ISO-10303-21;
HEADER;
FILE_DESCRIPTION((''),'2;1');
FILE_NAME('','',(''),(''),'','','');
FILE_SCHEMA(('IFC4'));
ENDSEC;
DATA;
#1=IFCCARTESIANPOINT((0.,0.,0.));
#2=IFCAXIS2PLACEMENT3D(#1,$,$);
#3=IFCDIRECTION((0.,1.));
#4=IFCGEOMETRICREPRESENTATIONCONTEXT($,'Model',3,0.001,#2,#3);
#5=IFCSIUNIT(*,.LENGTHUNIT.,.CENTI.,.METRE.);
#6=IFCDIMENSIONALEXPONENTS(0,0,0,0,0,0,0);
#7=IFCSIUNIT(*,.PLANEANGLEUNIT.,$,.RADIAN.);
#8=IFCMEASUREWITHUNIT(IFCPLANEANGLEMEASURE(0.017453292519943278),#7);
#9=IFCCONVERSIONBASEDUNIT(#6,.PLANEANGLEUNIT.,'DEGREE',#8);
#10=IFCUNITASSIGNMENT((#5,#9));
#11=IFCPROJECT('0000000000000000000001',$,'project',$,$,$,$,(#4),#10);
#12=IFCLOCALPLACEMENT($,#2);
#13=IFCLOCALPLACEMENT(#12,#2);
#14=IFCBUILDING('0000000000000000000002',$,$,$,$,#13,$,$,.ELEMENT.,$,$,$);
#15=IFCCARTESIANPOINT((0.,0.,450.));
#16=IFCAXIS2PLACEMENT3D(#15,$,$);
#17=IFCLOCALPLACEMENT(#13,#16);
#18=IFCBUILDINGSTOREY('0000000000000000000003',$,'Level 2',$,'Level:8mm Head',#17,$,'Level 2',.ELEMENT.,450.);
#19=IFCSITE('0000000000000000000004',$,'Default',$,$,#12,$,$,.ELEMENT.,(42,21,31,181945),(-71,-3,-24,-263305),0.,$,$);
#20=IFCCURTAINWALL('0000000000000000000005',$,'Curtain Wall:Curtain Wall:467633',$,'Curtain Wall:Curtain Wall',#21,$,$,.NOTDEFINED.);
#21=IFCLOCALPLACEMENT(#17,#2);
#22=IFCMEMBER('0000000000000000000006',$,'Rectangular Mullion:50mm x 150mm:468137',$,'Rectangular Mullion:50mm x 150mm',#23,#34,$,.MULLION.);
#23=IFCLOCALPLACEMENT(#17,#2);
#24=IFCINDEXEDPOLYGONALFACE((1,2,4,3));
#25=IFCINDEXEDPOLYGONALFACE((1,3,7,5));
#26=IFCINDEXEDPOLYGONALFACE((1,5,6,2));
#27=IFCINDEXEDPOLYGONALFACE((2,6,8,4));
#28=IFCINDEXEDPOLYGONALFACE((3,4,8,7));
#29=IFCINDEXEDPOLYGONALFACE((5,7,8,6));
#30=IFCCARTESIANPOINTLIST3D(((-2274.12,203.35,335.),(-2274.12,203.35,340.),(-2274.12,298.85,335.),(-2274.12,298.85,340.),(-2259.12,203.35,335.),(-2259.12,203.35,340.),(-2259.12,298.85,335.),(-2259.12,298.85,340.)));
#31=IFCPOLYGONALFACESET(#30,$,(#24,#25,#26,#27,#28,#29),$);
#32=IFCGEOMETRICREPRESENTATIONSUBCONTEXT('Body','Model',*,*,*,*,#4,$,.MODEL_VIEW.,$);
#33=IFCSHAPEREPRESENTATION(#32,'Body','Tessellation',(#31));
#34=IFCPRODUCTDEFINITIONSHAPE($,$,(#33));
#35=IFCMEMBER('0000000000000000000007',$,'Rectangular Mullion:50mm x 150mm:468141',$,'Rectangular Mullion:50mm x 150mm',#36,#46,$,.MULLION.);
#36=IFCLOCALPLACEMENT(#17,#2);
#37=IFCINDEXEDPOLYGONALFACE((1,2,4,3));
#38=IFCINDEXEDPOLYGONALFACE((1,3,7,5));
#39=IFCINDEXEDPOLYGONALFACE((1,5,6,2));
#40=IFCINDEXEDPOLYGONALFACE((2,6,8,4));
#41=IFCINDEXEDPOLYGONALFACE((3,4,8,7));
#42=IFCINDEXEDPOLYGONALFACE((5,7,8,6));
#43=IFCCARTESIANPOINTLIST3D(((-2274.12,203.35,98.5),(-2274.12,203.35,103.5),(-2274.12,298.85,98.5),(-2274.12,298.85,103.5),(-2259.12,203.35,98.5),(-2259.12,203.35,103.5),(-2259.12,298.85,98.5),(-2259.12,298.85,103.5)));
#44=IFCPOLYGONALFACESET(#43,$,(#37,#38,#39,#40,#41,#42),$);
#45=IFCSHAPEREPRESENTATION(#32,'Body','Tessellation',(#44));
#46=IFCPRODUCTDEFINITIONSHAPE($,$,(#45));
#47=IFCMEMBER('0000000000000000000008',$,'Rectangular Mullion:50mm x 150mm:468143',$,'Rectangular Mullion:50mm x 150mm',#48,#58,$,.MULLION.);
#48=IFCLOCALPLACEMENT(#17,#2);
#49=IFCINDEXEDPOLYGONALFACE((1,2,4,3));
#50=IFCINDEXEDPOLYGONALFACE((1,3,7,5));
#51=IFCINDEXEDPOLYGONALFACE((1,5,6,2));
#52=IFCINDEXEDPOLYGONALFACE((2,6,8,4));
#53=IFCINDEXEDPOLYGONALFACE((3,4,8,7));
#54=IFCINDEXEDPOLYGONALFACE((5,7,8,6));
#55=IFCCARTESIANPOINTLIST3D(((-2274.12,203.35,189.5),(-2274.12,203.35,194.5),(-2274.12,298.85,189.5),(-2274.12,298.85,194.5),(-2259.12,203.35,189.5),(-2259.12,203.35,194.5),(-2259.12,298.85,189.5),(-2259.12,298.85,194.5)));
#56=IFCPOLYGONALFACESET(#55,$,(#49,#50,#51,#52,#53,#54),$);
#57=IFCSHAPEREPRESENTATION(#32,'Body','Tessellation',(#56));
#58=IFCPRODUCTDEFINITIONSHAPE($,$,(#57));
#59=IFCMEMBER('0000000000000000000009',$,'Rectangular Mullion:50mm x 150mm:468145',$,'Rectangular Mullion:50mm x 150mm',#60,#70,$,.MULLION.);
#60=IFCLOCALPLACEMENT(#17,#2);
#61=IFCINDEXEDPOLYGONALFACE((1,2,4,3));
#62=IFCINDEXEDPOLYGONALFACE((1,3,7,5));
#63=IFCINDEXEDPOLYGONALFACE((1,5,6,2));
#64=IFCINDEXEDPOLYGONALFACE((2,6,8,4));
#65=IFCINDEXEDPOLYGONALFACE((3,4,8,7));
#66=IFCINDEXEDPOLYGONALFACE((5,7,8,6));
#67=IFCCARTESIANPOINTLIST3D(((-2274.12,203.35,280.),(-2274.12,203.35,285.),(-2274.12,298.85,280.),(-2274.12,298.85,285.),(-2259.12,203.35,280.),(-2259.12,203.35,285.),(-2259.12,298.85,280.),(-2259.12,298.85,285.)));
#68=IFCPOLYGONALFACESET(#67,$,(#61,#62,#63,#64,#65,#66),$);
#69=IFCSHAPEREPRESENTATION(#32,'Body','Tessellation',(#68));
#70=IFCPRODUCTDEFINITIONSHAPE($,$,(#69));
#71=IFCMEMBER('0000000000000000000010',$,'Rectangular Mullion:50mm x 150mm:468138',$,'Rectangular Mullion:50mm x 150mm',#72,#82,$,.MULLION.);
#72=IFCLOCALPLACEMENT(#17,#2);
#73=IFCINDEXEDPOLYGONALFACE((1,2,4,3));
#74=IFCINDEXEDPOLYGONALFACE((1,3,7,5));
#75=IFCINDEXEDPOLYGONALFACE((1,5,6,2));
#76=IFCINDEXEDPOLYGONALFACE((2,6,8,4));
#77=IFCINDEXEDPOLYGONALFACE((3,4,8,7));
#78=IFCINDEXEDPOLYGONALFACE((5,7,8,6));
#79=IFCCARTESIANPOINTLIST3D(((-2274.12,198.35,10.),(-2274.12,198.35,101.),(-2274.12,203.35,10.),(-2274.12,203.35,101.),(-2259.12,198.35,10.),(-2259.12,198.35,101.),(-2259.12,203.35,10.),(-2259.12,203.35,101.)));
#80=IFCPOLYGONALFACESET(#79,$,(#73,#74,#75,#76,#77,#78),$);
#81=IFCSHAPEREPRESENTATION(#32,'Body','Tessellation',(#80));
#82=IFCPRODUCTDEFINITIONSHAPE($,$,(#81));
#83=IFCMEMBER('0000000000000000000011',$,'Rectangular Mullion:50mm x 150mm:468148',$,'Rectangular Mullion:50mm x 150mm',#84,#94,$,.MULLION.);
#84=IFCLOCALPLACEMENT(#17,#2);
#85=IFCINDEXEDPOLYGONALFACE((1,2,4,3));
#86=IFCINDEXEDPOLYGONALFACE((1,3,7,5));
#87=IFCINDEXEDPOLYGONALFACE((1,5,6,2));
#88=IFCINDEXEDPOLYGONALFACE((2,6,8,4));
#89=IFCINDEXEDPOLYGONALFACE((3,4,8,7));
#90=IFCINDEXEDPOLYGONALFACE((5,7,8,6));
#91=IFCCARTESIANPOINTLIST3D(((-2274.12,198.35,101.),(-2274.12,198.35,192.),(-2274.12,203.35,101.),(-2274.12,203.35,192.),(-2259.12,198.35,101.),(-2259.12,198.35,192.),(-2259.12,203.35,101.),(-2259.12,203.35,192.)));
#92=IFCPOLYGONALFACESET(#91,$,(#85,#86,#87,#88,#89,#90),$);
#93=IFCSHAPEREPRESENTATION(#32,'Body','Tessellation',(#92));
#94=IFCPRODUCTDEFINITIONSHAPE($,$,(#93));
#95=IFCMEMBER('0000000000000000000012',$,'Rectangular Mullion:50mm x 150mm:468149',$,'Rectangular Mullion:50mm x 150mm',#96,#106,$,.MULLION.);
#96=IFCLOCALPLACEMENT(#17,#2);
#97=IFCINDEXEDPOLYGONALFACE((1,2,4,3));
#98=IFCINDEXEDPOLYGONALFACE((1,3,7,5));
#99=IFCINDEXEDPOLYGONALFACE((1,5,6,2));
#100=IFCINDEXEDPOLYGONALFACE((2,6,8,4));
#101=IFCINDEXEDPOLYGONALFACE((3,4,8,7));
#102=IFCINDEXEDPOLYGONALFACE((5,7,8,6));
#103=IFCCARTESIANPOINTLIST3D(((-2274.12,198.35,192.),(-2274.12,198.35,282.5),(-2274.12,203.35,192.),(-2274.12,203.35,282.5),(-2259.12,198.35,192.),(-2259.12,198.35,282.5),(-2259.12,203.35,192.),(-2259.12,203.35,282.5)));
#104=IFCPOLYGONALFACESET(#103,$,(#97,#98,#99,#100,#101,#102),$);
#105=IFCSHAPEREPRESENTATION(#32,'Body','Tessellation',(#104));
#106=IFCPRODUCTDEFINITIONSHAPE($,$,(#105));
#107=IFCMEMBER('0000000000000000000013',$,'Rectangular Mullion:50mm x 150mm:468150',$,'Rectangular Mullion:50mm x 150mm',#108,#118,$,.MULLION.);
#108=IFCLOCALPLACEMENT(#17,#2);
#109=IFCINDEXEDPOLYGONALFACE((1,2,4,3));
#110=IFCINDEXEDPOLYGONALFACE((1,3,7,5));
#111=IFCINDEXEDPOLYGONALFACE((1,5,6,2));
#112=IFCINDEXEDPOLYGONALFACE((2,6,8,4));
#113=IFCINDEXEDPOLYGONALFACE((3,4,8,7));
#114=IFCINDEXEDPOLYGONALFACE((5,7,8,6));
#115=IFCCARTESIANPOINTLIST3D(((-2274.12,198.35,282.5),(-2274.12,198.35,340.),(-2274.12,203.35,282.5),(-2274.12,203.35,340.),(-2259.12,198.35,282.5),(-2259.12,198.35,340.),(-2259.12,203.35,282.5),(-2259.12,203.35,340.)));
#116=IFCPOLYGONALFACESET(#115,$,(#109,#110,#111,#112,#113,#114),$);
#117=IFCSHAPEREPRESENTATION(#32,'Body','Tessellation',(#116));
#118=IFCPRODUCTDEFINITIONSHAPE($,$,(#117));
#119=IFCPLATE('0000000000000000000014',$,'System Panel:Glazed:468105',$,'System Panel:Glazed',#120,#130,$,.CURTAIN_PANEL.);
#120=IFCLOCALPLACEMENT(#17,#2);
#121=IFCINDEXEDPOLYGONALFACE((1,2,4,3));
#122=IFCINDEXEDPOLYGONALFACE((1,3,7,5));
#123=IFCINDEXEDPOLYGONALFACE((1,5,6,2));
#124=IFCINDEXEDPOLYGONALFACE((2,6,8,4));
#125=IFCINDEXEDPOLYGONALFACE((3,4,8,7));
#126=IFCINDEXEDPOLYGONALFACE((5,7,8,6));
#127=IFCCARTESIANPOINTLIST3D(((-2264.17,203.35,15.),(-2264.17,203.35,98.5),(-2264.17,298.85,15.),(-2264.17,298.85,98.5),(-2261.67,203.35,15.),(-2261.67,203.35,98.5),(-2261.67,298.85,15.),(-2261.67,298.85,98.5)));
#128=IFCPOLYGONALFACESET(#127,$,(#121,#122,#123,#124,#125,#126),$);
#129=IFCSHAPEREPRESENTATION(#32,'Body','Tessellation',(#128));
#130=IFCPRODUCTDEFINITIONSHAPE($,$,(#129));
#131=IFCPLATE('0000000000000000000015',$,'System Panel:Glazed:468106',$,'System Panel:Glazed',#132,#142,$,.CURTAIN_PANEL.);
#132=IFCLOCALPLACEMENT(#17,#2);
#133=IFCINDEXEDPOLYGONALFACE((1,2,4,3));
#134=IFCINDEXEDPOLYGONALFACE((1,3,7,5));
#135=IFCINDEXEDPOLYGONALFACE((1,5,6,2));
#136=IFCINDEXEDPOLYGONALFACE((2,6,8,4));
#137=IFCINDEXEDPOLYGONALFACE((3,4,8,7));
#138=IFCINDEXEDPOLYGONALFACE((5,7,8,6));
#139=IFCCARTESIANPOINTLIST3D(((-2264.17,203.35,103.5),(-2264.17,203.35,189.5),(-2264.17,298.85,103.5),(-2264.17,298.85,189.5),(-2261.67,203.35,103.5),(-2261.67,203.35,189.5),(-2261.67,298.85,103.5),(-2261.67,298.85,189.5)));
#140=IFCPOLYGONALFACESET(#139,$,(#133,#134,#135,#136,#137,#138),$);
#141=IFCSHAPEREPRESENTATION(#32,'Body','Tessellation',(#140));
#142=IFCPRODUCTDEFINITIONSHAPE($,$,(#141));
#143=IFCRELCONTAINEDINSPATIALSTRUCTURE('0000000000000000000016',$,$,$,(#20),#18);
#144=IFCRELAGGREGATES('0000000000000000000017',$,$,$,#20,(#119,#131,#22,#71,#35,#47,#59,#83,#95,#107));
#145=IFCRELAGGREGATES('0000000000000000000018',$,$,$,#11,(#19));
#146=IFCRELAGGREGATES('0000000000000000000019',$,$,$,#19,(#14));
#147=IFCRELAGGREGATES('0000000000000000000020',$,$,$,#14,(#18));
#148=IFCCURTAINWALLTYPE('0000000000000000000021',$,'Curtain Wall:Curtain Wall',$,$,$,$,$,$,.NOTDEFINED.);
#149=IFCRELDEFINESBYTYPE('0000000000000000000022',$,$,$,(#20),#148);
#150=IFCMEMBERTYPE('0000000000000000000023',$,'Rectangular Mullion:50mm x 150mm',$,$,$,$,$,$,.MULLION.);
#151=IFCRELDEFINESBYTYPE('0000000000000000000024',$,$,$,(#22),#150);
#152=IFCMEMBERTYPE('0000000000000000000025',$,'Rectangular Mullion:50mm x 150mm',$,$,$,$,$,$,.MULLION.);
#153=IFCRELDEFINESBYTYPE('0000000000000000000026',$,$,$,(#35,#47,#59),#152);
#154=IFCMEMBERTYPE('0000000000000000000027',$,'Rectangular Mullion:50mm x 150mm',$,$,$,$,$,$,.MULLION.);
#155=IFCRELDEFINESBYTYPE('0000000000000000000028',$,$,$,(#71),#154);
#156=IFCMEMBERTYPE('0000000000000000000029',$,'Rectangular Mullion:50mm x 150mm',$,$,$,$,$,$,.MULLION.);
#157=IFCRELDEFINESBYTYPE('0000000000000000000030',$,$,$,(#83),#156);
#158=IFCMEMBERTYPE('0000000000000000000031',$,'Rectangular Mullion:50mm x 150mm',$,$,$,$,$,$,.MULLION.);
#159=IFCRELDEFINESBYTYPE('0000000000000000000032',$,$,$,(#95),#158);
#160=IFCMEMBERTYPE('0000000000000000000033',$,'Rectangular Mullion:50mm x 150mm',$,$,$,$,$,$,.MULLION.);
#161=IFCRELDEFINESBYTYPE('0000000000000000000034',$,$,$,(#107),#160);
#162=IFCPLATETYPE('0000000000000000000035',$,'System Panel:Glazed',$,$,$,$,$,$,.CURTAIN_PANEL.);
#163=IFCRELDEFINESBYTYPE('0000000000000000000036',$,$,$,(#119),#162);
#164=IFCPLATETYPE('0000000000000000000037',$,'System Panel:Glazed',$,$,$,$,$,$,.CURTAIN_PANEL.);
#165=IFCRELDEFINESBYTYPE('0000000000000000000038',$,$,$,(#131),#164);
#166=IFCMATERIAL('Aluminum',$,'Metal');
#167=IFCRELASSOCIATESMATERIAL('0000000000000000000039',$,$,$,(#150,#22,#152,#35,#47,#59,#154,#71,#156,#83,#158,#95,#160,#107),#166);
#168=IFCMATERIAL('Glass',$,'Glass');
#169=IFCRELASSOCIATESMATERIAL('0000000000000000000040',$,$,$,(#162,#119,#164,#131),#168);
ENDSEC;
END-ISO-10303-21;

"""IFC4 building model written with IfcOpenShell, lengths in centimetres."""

from ifc_helpers import new_model, entity, si_unit, converted_unit, direction, frame, origin, place, context, subcontext, project, spatial, indexed_curve, outline, extrude, source, transform, mapped, material, type_object, type_shapes, element, aggregate, save


model = new_model("IFC4")

# Units and contexts
model_context = context("Model", 3, precision=0.001, world=origin(), true_north=direction((0.0, 1.0)))
body_context = subcontext(model_context, "Body", "Model", "MODEL_VIEW")
ifc_project = project(units=[si_unit("LENGTHUNIT", "METRE", prefix="CENTI"), converted_unit("PLANEANGLEUNIT", "DEGREE", entity("IfcPlaneAngleMeasure", 0.017453292519943278), si_unit("PLANEANGLEUNIT", "RADIAN"), dimensions=[0, 0, 0, 0, 0, 0, 0])], contexts=[model_context])

# Site, building, storey
site_placement = place(None, origin())
site = spatial("IfcSite", under=ifc_project, at=site_placement, Name="Default", CompositionType="ELEMENT", RefLatitude=(42, 21, 31, 181945), RefLongitude=(-71, -3, -24, -263305), RefElevation=0.0)
building_placement = place(site_placement, origin())
building = spatial("IfcBuilding", under=site, at=building_placement, CompositionType="ELEMENT")
storey_placement = place(building_placement, frame((0.0, 0.0, 450.0)))
storey = spatial("IfcBuildingStorey", under=building, at=storey_placement, Name="Level 2", ObjectType="Level:8mm Head", LongName="Level 2", CompositionType="ELEMENT", Elevation=450.0)

# Curtain wall, members, plates
curtain_wall_type = type_object("IfcCurtainWallType", Name="Curtain Wall:Curtain Wall", PredefinedType="NOTDEFINED")
curtain_wall_placement = place(storey_placement, frame((0.0, 0.0, -450.0)))
curtain_wall = element("IfcCurtainWall", 1, at=curtain_wall_placement, inside=storey, type_object=curtain_wall_type, Name="Curtain Wall:Curtain Wall:467633", ObjectType="Curtain Wall:Curtain Wall", PredefinedType="NOTDEFINED")
ifc_material_1 = material(Name="Aluminum", Category="Metal")
member_type_1 = type_object("IfcMemberType", Name="Rectangular Mullion:50mm x 150mm", PredefinedType="MULLION", material=ifc_material_1)
shared_shape_1 = source(origin(), body_context, "Body", "SweptSolid", [
    extrude(outline(indexed_curve([(-2.5, -7.5), (2.5, -7.5), (2.5, 7.5), (-2.5, 7.5), (-2.5, -7.5)], self_intersect=False)), frame((-2.5, 0.0, -95.5), z_axis=(0.0, 0.0, 1.0), x_axis=(-1.0, 0.0, 0.0)), (0.0, 0.0, 1.0), 95.5),
])
type_shapes(member_type_1, [shared_shape_1])
member_1_placement = place(curtain_wall_placement, frame((-2266.62, 203.35, 790.0), z_axis=(0.0, -1.0, 0.0), x_axis=(0.0, 0.0, 1.0)))
member_1 = element("IfcMember", 2, at=member_1_placement, type_object=member_type_1, material=ifc_material_1, Name="Rectangular Mullion:50mm x 150mm:468137", ObjectType="Rectangular Mullion:50mm x 150mm", PredefinedType="MULLION", context=body_context, shape_type="MappedRepresentation", body=[
    mapped(shared_shape_1, transform((0.0, 0.0, 0.0), scale=1.0)),
])
member_type_2 = type_object("IfcMemberType", Name="Rectangular Mullion:50mm x 150mm", PredefinedType="MULLION", material=ifc_material_1)
shared_shape_2 = source(origin(), body_context, "Body", "SweptSolid", [
    extrude(outline(indexed_curve([(-2.5, -7.5), (2.5, -7.5), (2.5, 7.5), (-2.5, 7.5), (-2.5, -7.5)], self_intersect=False)), frame((0.0, 0.0, -95.5), z_axis=(0.0, 0.0, 1.0), x_axis=(-1.0, 0.0, 0.0)), (0.0, 0.0, 1.0), 95.5),
])
type_shapes(member_type_2, [shared_shape_2])
member_2_placement = place(curtain_wall_placement, frame((-2266.62, 203.35, 551.0), z_axis=(0.0, -1.0, 0.0), x_axis=(0.0, 0.0, 1.0)))
member_2 = element("IfcMember", 3, at=member_2_placement, type_object=member_type_2, material=ifc_material_1, Name="Rectangular Mullion:50mm x 150mm:468141", ObjectType="Rectangular Mullion:50mm x 150mm", PredefinedType="MULLION", context=body_context, shape_type="MappedRepresentation", body=[
    mapped(shared_shape_2, transform((0.0, 0.0, 0.0), scale=1.0)),
])
member_3_placement = place(curtain_wall_placement, frame((-2266.62, 203.35, 642.0), z_axis=(0.0, -1.0, 0.0), x_axis=(0.0, 0.0, 1.0)))
member_3 = element("IfcMember", 4, at=member_3_placement, type_object=member_type_2, material=ifc_material_1, Name="Rectangular Mullion:50mm x 150mm:468143", ObjectType="Rectangular Mullion:50mm x 150mm", PredefinedType="MULLION", context=body_context, shape_type="MappedRepresentation", body=[
    mapped(shared_shape_2, transform((0.0, 0.0, 0.0), scale=1.0)),
])
member_4_placement = place(curtain_wall_placement, frame((-2266.62, 203.35, 732.5), z_axis=(0.0, -1.0, 0.0), x_axis=(0.0, 0.0, 1.0)))
member_4 = element("IfcMember", 5, at=member_4_placement, type_object=member_type_2, material=ifc_material_1, Name="Rectangular Mullion:50mm x 150mm:468145", ObjectType="Rectangular Mullion:50mm x 150mm", PredefinedType="MULLION", context=body_context, shape_type="MappedRepresentation", body=[
    mapped(shared_shape_2, transform((0.0, 0.0, 0.0), scale=1.0)),
])
member_type_3 = type_object("IfcMemberType", Name="Rectangular Mullion:50mm x 150mm", PredefinedType="MULLION", material=ifc_material_1)
shared_shape_3 = source(origin(), body_context, "Body", "SweptSolid", [
    extrude(outline(indexed_curve([(-2.5, -7.5), (2.5, -7.5), (2.5, 7.5), (-2.5, 7.5), (-2.5, -7.5)], self_intersect=False)), frame((-2.5, 0.0, -91.0), z_axis=(0.0, 0.0, 1.0), x_axis=(-1.0, 0.0, 0.0)), (0.0, 0.0, 1.0), 91.0),
])
type_shapes(member_type_3, [shared_shape_3])
member_5_placement = place(curtain_wall_placement, frame((-2266.62, 198.35, 460.0), z_axis=(0.0, 0.0, -1.0), x_axis=(0.0, -1.0, 0.0)))
member_5 = element("IfcMember", 6, at=member_5_placement, type_object=member_type_3, material=ifc_material_1, Name="Rectangular Mullion:50mm x 150mm:468138", ObjectType="Rectangular Mullion:50mm x 150mm", PredefinedType="MULLION", context=body_context, shape_type="MappedRepresentation", body=[
    mapped(shared_shape_3, transform((0.0, 0.0, 0.0), scale=1.0)),
])
member_type_4 = type_object("IfcMemberType", Name="Rectangular Mullion:50mm x 150mm", PredefinedType="MULLION", material=ifc_material_1)
shared_shape_4 = source(origin(), body_context, "Body", "SweptSolid", [
    extrude(outline(indexed_curve([(-2.5, -7.5), (2.5, -7.5), (2.5, 7.5), (-2.5, 7.5), (-2.5, -7.5)], self_intersect=False)), frame((-2.5, 0.0, -91.0), z_axis=(0.0, 0.0, 1.0), x_axis=(-1.0, 0.0, 0.0)), (0.0, 0.0, 1.0), 91.0),
])
type_shapes(member_type_4, [shared_shape_4])
member_6_placement = place(curtain_wall_placement, frame((-2266.62, 198.35, 551.0), z_axis=(0.0, 0.0, -1.0), x_axis=(0.0, -1.0, 0.0)))
member_6 = element("IfcMember", 7, at=member_6_placement, type_object=member_type_4, material=ifc_material_1, Name="Rectangular Mullion:50mm x 150mm:468148", ObjectType="Rectangular Mullion:50mm x 150mm", PredefinedType="MULLION", context=body_context, shape_type="MappedRepresentation", body=[
    mapped(shared_shape_4, transform((0.0, 0.0, 0.0), scale=1.0)),
])
member_type_5 = type_object("IfcMemberType", Name="Rectangular Mullion:50mm x 150mm", PredefinedType="MULLION", material=ifc_material_1)
shared_shape_5 = source(origin(), body_context, "Body", "SweptSolid", [
    extrude(outline(indexed_curve([(-2.5, -7.5), (2.5, -7.5), (2.5, 7.5), (-2.5, 7.5), (-2.5, -7.5)], self_intersect=False)), frame((-2.5, 0.0, -90.5), z_axis=(0.0, 0.0, 1.0), x_axis=(-1.0, 0.0, 0.0)), (0.0, 0.0, 1.0), 90.5),
])
type_shapes(member_type_5, [shared_shape_5])
member_7_placement = place(curtain_wall_placement, frame((-2266.62, 198.35, 642.0), z_axis=(0.0, 0.0, -1.0), x_axis=(0.0, -1.0, 0.0)))
member_7 = element("IfcMember", 8, at=member_7_placement, type_object=member_type_5, material=ifc_material_1, Name="Rectangular Mullion:50mm x 150mm:468149", ObjectType="Rectangular Mullion:50mm x 150mm", PredefinedType="MULLION", context=body_context, shape_type="MappedRepresentation", body=[
    mapped(shared_shape_5, transform((0.0, 0.0, 0.0), scale=1.0)),
])
member_type_6 = type_object("IfcMemberType", Name="Rectangular Mullion:50mm x 150mm", PredefinedType="MULLION", material=ifc_material_1)
shared_shape_6 = source(origin(), body_context, "Body", "SweptSolid", [
    extrude(outline(indexed_curve([(-2.5, -7.5), (2.5, -7.5), (2.5, 7.5), (-2.5, 7.5), (-2.5, -7.5)], self_intersect=False)), frame((-2.5, 0.0, -57.5), z_axis=(0.0, 0.0, 1.0), x_axis=(-1.0, 0.0, 0.0)), (0.0, 0.0, 1.0), 57.5),
])
type_shapes(member_type_6, [shared_shape_6])
member_8_placement = place(curtain_wall_placement, frame((-2266.62, 198.35, 732.5), z_axis=(0.0, 0.0, -1.0), x_axis=(0.0, -1.0, 0.0)))
member_8 = element("IfcMember", 9, at=member_8_placement, type_object=member_type_6, material=ifc_material_1, Name="Rectangular Mullion:50mm x 150mm:468150", ObjectType="Rectangular Mullion:50mm x 150mm", PredefinedType="MULLION", context=body_context, shape_type="MappedRepresentation", body=[
    mapped(shared_shape_6, transform((0.0, 0.0, 0.0), scale=1.0)),
])
ifc_material_2 = material(Name="Glass", Category="Glass")
plate_type_1 = type_object("IfcPlateType", Name="System Panel:Glazed", PredefinedType="CURTAIN_PANEL", material=ifc_material_2)
shared_shape_7 = source(origin(), body_context, "Body", "SweptSolid", [
    extrude(outline(indexed_curve([(-1.25, -47.75), (1.25, -47.75), (1.25, 47.75), (-1.25, 47.75), (-1.25, -47.75)], self_intersect=False)), frame((0.0, 3.7, 0.0), z_axis=(0.0, 0.0, 1.0), x_axis=(0.0, 1.0, 0.0)), (0.0, 0.0, 1.0), 83.5),
])
type_shapes(plate_type_1, [shared_shape_7])
plate_1_placement = place(curtain_wall_placement, frame((-2266.62, 251.1, 465.0), z_axis=(0.0, 0.0, 1.0), x_axis=(0.0, -1.0, 0.0)))
plate_1 = element("IfcPlate", 10, at=plate_1_placement, type_object=plate_type_1, material=ifc_material_2, Name="System Panel:Glazed:468105", ObjectType="System Panel:Glazed", PredefinedType="CURTAIN_PANEL", context=body_context, shape_type="MappedRepresentation", body=[
    mapped(shared_shape_7, transform((0.0, 0.0, 0.0), scale=1.0)),
])
plate_type_2 = type_object("IfcPlateType", Name="System Panel:Glazed", PredefinedType="CURTAIN_PANEL", material=ifc_material_2)
shared_shape_8 = source(origin(), body_context, "Body", "SweptSolid", [
    extrude(outline(indexed_curve([(-1.25, -47.75), (1.25, -47.75), (1.25, 47.75), (-1.25, 47.75), (-1.25, -47.75)], self_intersect=False)), frame((0.0, 3.7, 0.0), z_axis=(0.0, 0.0, 1.0), x_axis=(0.0, 1.0, 0.0)), (0.0, 0.0, 1.0), 86.0),
])
type_shapes(plate_type_2, [shared_shape_8])
plate_2_placement = place(curtain_wall_placement, frame((-2266.62, 251.1, 553.5), z_axis=(0.0, 0.0, 1.0), x_axis=(0.0, -1.0, 0.0)))
plate_2 = element("IfcPlate", 11, at=plate_2_placement, type_object=plate_type_2, material=ifc_material_2, Name="System Panel:Glazed:468106", ObjectType="System Panel:Glazed", PredefinedType="CURTAIN_PANEL", context=body_context, shape_type="MappedRepresentation", body=[
    mapped(shared_shape_8, transform((0.0, 0.0, 0.0), scale=1.0)),
])
aggregate(curtain_wall, [plate_1, plate_2, member_1, member_5, member_2, member_3, member_4, member_6, member_7, member_8])

save(model, "model.ifc")
